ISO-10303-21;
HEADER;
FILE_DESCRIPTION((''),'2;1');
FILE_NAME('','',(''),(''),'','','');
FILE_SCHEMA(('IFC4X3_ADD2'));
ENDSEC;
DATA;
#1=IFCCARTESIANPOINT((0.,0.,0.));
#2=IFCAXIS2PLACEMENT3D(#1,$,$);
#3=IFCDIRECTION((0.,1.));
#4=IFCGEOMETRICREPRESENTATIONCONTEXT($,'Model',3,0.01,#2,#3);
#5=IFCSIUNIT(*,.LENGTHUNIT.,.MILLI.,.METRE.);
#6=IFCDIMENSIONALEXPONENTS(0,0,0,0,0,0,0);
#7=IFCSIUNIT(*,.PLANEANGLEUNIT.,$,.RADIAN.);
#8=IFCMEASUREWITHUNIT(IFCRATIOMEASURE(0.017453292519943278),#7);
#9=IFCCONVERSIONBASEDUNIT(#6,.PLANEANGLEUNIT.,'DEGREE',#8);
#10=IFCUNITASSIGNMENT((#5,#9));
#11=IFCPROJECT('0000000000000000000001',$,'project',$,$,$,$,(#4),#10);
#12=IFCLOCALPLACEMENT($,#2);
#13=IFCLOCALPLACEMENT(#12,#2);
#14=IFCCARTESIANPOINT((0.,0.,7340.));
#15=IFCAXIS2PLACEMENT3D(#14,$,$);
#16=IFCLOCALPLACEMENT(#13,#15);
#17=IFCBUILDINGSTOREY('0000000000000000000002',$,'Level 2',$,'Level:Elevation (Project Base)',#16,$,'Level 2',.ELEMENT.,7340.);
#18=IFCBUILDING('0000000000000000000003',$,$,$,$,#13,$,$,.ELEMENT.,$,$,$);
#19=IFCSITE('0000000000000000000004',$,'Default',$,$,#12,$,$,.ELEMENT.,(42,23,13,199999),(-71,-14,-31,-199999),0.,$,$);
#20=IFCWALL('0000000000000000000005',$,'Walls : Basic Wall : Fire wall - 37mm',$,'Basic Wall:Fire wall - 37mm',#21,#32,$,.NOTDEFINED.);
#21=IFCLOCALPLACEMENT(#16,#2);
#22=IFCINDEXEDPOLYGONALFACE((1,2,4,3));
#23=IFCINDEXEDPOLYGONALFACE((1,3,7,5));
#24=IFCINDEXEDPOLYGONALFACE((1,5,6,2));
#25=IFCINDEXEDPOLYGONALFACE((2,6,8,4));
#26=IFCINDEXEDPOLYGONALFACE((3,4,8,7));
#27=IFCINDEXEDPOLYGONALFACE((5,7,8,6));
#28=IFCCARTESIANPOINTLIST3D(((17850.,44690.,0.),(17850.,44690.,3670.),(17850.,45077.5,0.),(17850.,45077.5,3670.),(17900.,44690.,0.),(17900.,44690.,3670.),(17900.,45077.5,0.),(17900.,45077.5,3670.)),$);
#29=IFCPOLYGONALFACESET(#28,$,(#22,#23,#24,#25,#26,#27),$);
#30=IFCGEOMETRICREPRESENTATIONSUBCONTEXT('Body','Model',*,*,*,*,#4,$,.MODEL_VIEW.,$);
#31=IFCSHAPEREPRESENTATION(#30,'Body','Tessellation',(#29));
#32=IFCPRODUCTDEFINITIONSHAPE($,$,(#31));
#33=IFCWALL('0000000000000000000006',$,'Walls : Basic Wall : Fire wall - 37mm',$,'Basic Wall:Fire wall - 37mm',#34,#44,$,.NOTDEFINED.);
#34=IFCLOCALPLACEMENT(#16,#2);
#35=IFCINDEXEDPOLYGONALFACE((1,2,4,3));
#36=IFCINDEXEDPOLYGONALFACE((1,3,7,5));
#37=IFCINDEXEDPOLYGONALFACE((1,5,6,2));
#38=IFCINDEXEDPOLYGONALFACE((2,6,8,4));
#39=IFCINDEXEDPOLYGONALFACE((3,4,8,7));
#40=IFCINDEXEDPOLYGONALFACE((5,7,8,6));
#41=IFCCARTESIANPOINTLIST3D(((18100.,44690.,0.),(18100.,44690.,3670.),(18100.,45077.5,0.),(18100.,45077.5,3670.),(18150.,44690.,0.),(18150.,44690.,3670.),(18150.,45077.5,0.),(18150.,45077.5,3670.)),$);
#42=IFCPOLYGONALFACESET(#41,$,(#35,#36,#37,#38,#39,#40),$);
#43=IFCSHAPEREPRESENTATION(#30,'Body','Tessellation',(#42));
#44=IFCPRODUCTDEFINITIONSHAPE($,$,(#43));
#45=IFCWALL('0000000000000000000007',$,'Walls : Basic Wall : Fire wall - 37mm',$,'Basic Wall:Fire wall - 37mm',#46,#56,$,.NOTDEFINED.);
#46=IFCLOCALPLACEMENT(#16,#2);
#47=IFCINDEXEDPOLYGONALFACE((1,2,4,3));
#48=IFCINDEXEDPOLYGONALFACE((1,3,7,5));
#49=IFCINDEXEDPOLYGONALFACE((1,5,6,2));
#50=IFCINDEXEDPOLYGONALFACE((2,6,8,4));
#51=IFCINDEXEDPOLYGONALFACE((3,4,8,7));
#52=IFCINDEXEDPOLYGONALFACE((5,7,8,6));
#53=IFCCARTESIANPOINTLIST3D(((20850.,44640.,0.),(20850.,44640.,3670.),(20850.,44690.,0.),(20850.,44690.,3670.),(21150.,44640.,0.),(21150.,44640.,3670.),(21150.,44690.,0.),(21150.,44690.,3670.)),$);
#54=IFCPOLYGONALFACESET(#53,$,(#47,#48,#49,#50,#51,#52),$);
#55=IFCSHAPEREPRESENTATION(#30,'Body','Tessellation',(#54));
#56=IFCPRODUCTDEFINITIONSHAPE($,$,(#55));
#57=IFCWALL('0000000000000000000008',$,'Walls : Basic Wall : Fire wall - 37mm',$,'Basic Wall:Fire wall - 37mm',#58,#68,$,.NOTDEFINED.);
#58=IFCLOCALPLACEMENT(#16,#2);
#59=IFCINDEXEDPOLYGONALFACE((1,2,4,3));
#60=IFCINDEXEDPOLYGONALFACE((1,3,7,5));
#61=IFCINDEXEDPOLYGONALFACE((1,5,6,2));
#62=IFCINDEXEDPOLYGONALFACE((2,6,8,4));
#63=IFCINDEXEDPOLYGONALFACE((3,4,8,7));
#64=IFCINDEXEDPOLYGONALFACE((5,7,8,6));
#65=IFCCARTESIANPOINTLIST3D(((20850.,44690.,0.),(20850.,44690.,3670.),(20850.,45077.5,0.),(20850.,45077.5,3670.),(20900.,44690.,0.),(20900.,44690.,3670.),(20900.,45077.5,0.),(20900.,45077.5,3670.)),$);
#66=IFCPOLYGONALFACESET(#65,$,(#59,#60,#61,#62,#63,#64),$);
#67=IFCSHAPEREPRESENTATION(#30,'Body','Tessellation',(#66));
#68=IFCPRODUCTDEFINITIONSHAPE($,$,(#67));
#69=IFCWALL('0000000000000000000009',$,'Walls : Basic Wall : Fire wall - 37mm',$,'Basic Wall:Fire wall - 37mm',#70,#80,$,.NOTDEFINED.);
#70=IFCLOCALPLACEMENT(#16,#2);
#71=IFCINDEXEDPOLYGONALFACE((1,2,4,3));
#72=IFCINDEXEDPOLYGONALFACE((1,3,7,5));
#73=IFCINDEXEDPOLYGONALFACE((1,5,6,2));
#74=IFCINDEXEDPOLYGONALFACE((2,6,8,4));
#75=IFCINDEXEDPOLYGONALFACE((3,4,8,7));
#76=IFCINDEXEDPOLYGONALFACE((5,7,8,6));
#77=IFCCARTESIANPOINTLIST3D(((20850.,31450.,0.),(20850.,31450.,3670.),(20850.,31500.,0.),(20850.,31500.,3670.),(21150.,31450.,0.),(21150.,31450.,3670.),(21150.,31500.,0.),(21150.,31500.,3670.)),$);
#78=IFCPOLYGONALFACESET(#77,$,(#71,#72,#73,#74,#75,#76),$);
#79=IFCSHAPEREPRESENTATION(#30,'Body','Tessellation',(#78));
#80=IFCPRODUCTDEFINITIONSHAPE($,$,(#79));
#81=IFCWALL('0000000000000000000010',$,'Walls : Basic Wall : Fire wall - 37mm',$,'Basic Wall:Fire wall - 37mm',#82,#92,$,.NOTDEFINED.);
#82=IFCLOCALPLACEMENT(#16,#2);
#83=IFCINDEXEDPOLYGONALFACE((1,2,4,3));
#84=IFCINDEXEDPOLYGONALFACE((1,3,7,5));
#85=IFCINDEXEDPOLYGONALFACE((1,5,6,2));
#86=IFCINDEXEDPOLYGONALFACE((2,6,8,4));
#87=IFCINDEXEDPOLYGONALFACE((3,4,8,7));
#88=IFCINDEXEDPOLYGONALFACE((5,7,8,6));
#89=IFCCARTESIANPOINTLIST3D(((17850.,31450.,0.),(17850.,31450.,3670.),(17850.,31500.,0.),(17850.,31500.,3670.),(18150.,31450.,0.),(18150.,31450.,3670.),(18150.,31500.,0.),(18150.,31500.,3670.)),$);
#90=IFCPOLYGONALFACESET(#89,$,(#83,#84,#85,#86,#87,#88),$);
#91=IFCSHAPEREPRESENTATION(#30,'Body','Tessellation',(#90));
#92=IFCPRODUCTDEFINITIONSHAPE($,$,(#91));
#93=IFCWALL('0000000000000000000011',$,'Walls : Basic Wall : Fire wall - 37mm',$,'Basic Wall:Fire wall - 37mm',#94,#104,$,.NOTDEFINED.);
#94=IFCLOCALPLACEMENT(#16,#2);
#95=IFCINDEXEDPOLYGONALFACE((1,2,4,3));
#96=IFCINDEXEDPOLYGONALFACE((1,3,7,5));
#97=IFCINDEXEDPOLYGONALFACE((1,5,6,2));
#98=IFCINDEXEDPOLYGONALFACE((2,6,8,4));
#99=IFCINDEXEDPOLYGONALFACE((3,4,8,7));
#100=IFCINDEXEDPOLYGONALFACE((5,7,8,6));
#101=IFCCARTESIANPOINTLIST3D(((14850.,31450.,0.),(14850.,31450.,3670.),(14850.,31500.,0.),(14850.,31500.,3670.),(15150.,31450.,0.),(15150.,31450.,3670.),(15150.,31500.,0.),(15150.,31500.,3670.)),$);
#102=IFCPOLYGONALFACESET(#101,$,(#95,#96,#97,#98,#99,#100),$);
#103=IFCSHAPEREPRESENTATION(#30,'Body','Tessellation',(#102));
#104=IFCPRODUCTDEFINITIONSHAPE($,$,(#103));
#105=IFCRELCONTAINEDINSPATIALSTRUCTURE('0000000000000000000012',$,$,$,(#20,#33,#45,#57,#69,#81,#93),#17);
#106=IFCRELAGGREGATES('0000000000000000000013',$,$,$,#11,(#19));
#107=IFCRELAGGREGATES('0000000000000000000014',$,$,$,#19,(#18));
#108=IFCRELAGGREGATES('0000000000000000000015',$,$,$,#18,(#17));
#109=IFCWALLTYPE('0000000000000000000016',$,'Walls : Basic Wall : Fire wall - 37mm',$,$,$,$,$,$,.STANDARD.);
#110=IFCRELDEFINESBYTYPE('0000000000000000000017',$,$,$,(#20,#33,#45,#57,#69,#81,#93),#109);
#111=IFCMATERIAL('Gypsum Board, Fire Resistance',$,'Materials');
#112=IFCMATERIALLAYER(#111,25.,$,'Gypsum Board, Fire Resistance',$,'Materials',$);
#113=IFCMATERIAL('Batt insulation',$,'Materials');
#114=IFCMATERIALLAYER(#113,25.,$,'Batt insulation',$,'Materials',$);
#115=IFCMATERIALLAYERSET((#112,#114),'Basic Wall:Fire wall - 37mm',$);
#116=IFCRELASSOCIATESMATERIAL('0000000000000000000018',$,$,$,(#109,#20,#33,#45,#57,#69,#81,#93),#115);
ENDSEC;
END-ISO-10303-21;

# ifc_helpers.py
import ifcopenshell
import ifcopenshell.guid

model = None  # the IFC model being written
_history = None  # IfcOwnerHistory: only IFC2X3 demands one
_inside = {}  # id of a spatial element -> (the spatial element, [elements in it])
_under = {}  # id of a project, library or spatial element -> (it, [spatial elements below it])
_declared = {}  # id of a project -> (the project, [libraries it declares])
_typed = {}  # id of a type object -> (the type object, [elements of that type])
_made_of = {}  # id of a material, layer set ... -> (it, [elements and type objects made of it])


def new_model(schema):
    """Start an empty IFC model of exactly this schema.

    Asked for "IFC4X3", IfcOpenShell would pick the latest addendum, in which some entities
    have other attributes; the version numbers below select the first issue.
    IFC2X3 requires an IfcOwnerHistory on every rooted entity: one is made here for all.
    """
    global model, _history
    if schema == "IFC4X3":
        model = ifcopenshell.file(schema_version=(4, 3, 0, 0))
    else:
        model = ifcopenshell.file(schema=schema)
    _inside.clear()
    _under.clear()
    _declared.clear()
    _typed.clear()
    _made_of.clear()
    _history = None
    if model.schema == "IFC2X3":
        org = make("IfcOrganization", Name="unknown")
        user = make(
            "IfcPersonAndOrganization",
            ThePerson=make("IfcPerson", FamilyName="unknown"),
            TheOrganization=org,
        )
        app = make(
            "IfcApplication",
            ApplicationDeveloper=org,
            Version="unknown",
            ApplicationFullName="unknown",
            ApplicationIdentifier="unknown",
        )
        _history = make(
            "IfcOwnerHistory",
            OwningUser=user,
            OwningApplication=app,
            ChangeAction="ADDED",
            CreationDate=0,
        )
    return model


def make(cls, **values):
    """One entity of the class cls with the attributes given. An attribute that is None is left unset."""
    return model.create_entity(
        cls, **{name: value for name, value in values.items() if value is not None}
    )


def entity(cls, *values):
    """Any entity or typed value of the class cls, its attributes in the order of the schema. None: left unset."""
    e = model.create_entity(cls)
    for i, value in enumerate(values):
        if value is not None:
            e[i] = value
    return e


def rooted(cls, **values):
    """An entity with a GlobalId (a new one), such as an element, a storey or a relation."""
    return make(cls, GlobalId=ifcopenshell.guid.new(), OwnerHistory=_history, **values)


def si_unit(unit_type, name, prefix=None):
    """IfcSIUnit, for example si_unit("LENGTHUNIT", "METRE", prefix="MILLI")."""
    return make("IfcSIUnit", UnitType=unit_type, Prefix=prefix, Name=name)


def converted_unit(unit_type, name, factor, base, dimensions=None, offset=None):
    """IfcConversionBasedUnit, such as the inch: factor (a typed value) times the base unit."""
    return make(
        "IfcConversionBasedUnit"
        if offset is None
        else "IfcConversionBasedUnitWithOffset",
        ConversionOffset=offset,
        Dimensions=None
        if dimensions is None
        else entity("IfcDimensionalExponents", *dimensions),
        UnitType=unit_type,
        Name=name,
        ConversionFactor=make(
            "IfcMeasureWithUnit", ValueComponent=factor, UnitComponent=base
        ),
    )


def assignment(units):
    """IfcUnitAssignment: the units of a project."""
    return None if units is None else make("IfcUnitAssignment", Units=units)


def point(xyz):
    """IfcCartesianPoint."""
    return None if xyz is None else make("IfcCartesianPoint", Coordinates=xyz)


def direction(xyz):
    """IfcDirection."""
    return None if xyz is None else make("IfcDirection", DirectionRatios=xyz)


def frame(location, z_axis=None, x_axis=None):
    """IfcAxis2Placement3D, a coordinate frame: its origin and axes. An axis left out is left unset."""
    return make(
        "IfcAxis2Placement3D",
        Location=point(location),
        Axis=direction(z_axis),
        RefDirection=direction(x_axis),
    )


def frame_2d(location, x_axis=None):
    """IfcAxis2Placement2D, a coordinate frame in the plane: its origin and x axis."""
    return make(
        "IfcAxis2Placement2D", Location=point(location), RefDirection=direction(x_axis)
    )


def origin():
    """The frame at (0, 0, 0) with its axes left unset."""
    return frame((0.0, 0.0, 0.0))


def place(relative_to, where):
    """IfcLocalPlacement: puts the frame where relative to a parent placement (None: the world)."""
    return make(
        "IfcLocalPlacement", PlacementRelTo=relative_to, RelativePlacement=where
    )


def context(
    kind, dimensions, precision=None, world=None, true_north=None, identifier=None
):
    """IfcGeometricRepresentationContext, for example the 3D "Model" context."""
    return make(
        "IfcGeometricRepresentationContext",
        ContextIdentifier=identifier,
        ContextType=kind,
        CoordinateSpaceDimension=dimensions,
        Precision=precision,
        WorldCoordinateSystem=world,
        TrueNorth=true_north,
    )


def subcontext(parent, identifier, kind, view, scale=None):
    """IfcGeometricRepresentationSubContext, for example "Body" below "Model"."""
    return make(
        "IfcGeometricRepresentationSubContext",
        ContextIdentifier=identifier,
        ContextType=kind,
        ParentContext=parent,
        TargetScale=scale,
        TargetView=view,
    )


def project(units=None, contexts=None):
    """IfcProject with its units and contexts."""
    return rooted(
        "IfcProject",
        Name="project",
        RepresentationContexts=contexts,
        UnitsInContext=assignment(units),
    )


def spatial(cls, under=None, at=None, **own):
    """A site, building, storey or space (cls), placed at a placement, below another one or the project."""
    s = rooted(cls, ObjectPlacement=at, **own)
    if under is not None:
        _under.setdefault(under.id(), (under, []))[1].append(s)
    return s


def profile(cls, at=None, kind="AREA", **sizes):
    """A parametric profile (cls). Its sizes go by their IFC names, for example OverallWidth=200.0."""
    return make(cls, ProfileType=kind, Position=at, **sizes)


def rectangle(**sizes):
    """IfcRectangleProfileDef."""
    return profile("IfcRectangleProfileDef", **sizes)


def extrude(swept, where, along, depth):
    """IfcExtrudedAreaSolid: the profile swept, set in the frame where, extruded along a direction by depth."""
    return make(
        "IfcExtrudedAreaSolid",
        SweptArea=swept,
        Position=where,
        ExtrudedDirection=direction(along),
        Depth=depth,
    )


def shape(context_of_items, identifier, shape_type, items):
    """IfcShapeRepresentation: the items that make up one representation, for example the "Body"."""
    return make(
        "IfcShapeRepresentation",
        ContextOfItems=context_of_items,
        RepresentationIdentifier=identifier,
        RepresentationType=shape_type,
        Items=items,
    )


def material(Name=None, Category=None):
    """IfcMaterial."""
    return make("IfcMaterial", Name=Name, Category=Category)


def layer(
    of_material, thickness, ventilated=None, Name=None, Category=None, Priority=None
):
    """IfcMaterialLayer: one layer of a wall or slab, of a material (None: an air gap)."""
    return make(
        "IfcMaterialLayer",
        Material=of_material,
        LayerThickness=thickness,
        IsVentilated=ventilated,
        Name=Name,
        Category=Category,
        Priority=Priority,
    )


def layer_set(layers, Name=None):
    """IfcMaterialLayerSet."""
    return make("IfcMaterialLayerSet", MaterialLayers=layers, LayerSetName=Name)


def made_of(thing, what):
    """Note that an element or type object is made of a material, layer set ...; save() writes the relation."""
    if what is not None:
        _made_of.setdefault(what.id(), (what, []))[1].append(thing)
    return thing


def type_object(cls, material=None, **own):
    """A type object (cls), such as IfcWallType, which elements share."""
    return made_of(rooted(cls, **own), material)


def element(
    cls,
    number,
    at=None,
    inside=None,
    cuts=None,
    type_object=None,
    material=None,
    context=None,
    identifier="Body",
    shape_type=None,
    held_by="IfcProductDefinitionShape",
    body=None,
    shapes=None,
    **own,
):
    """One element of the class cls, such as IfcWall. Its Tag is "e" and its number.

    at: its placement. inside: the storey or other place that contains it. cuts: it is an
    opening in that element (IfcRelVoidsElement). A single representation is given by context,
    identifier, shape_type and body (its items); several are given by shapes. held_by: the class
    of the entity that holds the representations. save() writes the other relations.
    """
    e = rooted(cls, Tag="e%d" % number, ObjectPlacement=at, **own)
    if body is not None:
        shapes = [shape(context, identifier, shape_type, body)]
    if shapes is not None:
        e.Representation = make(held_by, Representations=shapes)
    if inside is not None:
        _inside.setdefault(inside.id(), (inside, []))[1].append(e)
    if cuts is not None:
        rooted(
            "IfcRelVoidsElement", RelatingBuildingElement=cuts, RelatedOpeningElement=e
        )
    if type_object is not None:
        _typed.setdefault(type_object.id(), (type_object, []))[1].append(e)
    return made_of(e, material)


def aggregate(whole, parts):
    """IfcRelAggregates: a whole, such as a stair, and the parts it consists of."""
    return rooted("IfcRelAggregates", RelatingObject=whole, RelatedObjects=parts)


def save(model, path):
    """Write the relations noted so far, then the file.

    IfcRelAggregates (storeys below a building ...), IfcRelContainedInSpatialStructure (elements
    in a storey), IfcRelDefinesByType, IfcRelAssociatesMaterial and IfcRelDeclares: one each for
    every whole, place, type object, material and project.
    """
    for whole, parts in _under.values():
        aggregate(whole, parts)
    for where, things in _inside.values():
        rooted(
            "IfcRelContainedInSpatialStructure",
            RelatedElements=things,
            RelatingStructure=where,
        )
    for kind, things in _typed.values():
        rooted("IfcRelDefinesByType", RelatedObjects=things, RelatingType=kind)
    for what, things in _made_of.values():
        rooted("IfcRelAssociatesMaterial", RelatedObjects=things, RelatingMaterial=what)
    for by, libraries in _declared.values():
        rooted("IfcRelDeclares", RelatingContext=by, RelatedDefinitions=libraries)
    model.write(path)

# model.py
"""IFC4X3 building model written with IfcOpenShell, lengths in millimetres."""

from ifc_helpers import new_model, entity, si_unit, converted_unit, direction, frame, frame_2d, origin, place, context, subcontext, project, spatial, rectangle, extrude, material, layer, layer_set, type_object, element, save


model = new_model("IFC4X3")

# Units and contexts
model_context = context("Model", 3, precision=0.01, world=origin(), true_north=direction((0.0, 1.0)))
body_context = subcontext(model_context, "Body", "Model", "MODEL_VIEW")
ifc_project = project(units=[si_unit("LENGTHUNIT", "METRE", prefix="MILLI"), converted_unit("PLANEANGLEUNIT", "DEGREE", entity("IfcRatioMeasure", 0.017453292519943278), si_unit("PLANEANGLEUNIT", "RADIAN"), dimensions=[0, 0, 0, 0, 0, 0, 0])], contexts=[model_context])

# Site, building, storey
site_placement = place(None, origin())
site = spatial("IfcSite", under=ifc_project, at=site_placement, Name="Default", CompositionType="ELEMENT", RefLatitude=(42, 23, 13, 199999), RefLongitude=(-71, -14, -31, -199999), RefElevation=0.0)
building_placement = place(site_placement, origin())
building = spatial("IfcBuilding", under=site, at=building_placement, CompositionType="ELEMENT")
storey_placement = place(building_placement, frame((0.0, 0.0, 7340.0)))
storey = spatial("IfcBuildingStorey", under=building, at=storey_placement, Name="Level 2", ObjectType="Level:Elevation (Project Base)", LongName="Level 2", CompositionType="ELEMENT", Elevation=7340.0)

# Walls
ifc_material_1 = material(Name="Gypsum Board, Fire Resistance", Category="Materials")
ifc_layer_1 = layer(ifc_material_1, 25.0, Name="Gypsum Board, Fire Resistance", Category="Materials")
ifc_material_2 = material(Name="Batt insulation", Category="Materials")
ifc_layer_2 = layer(ifc_material_2, 25.0, Name="Batt insulation", Category="Materials")
ifc_layer_set = layer_set([ifc_layer_1, ifc_layer_2], Name="Basic Wall:Fire wall - 37mm")
wall_type = type_object("IfcWallType", Name="Walls : Basic Wall : Fire wall - 37mm", PredefinedType="STANDARD", material=ifc_layer_set)
for number, where, z_axis, x_axis, name in (
    (1, (17875.0, 45077.5, 0.0), (0.0, 0.0, 1.0), (0.0, -1.0, 0.0), "Walls : Basic Wall : Fire wall - 37mm"),
    (2, (18125.0, 45077.5, 0.0), (0.0, 0.0, 1.0), (0.0, -1.0, 0.0), "Walls : Basic Wall : Fire wall - 37mm"),
):
    element("IfcWall", number, at=place(storey_placement, frame(where, z_axis=z_axis, x_axis=x_axis)), inside=storey, type_object=wall_type, material=ifc_layer_set, Name=name, ObjectType="Basic Wall:Fire wall - 37mm", PredefinedType="NOTDEFINED", context=body_context, shape_type="SweptSolid", body=[
        extrude(rectangle(XDim=387.5, YDim=50.0, at=frame_2d((193.8, 0.0), x_axis=(-1.0, 0.0))), origin(), (0.0, 0.0, 1.0), 3670.0),
    ])
wall_1_placement = place(storey_placement, frame((20850.0, 44665.0, 0.0)))
element("IfcWall", 3, at=wall_1_placement, inside=storey, type_object=wall_type, material=ifc_layer_set, Name="Walls : Basic Wall : Fire wall - 37mm", ObjectType="Basic Wall:Fire wall - 37mm", PredefinedType="NOTDEFINED", context=body_context, shape_type="SweptSolid", body=[
    extrude(rectangle(XDim=300.0, YDim=50.0, at=frame_2d((150.0, 0.0), x_axis=(-1.0, 0.0))), origin(), (0.0, 0.0, 1.0), 3670.0),
])
wall_2_placement = place(storey_placement, frame((20875.0, 45077.5, 0.0), z_axis=(0.0, 0.0, 1.0), x_axis=(0.0, -1.0, 0.0)))
element("IfcWall", 4, at=wall_2_placement, inside=storey, type_object=wall_type, material=ifc_layer_set, Name="Walls : Basic Wall : Fire wall - 37mm", ObjectType="Basic Wall:Fire wall - 37mm", PredefinedType="NOTDEFINED", context=body_context, shape_type="SweptSolid", body=[
    extrude(rectangle(XDim=387.5, YDim=50.0, at=frame_2d((193.8, 0.0), x_axis=(-1.0, 0.0))), origin(), (0.0, 0.0, 1.0), 3670.0),
])
wall_3_placement = place(storey_placement, frame((20850.0, 31475.0, 0.0)))
element("IfcWall", 5, at=wall_3_placement, inside=storey, type_object=wall_type, material=ifc_layer_set, Name="Walls : Basic Wall : Fire wall - 37mm", ObjectType="Basic Wall:Fire wall - 37mm", PredefinedType="NOTDEFINED", context=body_context, shape_type="SweptSolid", body=[
    extrude(rectangle(XDim=300.0, YDim=50.0, at=frame_2d((150.0, 0.0), x_axis=(-1.0, 0.0))), origin(), (0.0, 0.0, 1.0), 3670.0),
])
for number, where, name in (
    (6, (17850.0, 31475.0, 0.0), "Walls : Basic Wall : Fire wall - 37mm"),
    (7, (14850.0, 31475.0, 0.0), "Walls : Basic Wall : Fire wall - 37mm"),
):
    element("IfcWall", number, at=place(storey_placement, frame(where)), inside=storey, type_object=wall_type, material=ifc_layer_set, Name=name, ObjectType="Basic Wall:Fire wall - 37mm", PredefinedType="NOTDEFINED", context=body_context, shape_type="SweptSolid", body=[
        extrude(rectangle(XDim=300.0, YDim=50.0, at=frame_2d((150.0, 0.0), x_axis=(-1.0, 0.0))), origin(), (0.0, 0.0, 1.0), 3670.0),
    ])

save(model, "model.ifc")
